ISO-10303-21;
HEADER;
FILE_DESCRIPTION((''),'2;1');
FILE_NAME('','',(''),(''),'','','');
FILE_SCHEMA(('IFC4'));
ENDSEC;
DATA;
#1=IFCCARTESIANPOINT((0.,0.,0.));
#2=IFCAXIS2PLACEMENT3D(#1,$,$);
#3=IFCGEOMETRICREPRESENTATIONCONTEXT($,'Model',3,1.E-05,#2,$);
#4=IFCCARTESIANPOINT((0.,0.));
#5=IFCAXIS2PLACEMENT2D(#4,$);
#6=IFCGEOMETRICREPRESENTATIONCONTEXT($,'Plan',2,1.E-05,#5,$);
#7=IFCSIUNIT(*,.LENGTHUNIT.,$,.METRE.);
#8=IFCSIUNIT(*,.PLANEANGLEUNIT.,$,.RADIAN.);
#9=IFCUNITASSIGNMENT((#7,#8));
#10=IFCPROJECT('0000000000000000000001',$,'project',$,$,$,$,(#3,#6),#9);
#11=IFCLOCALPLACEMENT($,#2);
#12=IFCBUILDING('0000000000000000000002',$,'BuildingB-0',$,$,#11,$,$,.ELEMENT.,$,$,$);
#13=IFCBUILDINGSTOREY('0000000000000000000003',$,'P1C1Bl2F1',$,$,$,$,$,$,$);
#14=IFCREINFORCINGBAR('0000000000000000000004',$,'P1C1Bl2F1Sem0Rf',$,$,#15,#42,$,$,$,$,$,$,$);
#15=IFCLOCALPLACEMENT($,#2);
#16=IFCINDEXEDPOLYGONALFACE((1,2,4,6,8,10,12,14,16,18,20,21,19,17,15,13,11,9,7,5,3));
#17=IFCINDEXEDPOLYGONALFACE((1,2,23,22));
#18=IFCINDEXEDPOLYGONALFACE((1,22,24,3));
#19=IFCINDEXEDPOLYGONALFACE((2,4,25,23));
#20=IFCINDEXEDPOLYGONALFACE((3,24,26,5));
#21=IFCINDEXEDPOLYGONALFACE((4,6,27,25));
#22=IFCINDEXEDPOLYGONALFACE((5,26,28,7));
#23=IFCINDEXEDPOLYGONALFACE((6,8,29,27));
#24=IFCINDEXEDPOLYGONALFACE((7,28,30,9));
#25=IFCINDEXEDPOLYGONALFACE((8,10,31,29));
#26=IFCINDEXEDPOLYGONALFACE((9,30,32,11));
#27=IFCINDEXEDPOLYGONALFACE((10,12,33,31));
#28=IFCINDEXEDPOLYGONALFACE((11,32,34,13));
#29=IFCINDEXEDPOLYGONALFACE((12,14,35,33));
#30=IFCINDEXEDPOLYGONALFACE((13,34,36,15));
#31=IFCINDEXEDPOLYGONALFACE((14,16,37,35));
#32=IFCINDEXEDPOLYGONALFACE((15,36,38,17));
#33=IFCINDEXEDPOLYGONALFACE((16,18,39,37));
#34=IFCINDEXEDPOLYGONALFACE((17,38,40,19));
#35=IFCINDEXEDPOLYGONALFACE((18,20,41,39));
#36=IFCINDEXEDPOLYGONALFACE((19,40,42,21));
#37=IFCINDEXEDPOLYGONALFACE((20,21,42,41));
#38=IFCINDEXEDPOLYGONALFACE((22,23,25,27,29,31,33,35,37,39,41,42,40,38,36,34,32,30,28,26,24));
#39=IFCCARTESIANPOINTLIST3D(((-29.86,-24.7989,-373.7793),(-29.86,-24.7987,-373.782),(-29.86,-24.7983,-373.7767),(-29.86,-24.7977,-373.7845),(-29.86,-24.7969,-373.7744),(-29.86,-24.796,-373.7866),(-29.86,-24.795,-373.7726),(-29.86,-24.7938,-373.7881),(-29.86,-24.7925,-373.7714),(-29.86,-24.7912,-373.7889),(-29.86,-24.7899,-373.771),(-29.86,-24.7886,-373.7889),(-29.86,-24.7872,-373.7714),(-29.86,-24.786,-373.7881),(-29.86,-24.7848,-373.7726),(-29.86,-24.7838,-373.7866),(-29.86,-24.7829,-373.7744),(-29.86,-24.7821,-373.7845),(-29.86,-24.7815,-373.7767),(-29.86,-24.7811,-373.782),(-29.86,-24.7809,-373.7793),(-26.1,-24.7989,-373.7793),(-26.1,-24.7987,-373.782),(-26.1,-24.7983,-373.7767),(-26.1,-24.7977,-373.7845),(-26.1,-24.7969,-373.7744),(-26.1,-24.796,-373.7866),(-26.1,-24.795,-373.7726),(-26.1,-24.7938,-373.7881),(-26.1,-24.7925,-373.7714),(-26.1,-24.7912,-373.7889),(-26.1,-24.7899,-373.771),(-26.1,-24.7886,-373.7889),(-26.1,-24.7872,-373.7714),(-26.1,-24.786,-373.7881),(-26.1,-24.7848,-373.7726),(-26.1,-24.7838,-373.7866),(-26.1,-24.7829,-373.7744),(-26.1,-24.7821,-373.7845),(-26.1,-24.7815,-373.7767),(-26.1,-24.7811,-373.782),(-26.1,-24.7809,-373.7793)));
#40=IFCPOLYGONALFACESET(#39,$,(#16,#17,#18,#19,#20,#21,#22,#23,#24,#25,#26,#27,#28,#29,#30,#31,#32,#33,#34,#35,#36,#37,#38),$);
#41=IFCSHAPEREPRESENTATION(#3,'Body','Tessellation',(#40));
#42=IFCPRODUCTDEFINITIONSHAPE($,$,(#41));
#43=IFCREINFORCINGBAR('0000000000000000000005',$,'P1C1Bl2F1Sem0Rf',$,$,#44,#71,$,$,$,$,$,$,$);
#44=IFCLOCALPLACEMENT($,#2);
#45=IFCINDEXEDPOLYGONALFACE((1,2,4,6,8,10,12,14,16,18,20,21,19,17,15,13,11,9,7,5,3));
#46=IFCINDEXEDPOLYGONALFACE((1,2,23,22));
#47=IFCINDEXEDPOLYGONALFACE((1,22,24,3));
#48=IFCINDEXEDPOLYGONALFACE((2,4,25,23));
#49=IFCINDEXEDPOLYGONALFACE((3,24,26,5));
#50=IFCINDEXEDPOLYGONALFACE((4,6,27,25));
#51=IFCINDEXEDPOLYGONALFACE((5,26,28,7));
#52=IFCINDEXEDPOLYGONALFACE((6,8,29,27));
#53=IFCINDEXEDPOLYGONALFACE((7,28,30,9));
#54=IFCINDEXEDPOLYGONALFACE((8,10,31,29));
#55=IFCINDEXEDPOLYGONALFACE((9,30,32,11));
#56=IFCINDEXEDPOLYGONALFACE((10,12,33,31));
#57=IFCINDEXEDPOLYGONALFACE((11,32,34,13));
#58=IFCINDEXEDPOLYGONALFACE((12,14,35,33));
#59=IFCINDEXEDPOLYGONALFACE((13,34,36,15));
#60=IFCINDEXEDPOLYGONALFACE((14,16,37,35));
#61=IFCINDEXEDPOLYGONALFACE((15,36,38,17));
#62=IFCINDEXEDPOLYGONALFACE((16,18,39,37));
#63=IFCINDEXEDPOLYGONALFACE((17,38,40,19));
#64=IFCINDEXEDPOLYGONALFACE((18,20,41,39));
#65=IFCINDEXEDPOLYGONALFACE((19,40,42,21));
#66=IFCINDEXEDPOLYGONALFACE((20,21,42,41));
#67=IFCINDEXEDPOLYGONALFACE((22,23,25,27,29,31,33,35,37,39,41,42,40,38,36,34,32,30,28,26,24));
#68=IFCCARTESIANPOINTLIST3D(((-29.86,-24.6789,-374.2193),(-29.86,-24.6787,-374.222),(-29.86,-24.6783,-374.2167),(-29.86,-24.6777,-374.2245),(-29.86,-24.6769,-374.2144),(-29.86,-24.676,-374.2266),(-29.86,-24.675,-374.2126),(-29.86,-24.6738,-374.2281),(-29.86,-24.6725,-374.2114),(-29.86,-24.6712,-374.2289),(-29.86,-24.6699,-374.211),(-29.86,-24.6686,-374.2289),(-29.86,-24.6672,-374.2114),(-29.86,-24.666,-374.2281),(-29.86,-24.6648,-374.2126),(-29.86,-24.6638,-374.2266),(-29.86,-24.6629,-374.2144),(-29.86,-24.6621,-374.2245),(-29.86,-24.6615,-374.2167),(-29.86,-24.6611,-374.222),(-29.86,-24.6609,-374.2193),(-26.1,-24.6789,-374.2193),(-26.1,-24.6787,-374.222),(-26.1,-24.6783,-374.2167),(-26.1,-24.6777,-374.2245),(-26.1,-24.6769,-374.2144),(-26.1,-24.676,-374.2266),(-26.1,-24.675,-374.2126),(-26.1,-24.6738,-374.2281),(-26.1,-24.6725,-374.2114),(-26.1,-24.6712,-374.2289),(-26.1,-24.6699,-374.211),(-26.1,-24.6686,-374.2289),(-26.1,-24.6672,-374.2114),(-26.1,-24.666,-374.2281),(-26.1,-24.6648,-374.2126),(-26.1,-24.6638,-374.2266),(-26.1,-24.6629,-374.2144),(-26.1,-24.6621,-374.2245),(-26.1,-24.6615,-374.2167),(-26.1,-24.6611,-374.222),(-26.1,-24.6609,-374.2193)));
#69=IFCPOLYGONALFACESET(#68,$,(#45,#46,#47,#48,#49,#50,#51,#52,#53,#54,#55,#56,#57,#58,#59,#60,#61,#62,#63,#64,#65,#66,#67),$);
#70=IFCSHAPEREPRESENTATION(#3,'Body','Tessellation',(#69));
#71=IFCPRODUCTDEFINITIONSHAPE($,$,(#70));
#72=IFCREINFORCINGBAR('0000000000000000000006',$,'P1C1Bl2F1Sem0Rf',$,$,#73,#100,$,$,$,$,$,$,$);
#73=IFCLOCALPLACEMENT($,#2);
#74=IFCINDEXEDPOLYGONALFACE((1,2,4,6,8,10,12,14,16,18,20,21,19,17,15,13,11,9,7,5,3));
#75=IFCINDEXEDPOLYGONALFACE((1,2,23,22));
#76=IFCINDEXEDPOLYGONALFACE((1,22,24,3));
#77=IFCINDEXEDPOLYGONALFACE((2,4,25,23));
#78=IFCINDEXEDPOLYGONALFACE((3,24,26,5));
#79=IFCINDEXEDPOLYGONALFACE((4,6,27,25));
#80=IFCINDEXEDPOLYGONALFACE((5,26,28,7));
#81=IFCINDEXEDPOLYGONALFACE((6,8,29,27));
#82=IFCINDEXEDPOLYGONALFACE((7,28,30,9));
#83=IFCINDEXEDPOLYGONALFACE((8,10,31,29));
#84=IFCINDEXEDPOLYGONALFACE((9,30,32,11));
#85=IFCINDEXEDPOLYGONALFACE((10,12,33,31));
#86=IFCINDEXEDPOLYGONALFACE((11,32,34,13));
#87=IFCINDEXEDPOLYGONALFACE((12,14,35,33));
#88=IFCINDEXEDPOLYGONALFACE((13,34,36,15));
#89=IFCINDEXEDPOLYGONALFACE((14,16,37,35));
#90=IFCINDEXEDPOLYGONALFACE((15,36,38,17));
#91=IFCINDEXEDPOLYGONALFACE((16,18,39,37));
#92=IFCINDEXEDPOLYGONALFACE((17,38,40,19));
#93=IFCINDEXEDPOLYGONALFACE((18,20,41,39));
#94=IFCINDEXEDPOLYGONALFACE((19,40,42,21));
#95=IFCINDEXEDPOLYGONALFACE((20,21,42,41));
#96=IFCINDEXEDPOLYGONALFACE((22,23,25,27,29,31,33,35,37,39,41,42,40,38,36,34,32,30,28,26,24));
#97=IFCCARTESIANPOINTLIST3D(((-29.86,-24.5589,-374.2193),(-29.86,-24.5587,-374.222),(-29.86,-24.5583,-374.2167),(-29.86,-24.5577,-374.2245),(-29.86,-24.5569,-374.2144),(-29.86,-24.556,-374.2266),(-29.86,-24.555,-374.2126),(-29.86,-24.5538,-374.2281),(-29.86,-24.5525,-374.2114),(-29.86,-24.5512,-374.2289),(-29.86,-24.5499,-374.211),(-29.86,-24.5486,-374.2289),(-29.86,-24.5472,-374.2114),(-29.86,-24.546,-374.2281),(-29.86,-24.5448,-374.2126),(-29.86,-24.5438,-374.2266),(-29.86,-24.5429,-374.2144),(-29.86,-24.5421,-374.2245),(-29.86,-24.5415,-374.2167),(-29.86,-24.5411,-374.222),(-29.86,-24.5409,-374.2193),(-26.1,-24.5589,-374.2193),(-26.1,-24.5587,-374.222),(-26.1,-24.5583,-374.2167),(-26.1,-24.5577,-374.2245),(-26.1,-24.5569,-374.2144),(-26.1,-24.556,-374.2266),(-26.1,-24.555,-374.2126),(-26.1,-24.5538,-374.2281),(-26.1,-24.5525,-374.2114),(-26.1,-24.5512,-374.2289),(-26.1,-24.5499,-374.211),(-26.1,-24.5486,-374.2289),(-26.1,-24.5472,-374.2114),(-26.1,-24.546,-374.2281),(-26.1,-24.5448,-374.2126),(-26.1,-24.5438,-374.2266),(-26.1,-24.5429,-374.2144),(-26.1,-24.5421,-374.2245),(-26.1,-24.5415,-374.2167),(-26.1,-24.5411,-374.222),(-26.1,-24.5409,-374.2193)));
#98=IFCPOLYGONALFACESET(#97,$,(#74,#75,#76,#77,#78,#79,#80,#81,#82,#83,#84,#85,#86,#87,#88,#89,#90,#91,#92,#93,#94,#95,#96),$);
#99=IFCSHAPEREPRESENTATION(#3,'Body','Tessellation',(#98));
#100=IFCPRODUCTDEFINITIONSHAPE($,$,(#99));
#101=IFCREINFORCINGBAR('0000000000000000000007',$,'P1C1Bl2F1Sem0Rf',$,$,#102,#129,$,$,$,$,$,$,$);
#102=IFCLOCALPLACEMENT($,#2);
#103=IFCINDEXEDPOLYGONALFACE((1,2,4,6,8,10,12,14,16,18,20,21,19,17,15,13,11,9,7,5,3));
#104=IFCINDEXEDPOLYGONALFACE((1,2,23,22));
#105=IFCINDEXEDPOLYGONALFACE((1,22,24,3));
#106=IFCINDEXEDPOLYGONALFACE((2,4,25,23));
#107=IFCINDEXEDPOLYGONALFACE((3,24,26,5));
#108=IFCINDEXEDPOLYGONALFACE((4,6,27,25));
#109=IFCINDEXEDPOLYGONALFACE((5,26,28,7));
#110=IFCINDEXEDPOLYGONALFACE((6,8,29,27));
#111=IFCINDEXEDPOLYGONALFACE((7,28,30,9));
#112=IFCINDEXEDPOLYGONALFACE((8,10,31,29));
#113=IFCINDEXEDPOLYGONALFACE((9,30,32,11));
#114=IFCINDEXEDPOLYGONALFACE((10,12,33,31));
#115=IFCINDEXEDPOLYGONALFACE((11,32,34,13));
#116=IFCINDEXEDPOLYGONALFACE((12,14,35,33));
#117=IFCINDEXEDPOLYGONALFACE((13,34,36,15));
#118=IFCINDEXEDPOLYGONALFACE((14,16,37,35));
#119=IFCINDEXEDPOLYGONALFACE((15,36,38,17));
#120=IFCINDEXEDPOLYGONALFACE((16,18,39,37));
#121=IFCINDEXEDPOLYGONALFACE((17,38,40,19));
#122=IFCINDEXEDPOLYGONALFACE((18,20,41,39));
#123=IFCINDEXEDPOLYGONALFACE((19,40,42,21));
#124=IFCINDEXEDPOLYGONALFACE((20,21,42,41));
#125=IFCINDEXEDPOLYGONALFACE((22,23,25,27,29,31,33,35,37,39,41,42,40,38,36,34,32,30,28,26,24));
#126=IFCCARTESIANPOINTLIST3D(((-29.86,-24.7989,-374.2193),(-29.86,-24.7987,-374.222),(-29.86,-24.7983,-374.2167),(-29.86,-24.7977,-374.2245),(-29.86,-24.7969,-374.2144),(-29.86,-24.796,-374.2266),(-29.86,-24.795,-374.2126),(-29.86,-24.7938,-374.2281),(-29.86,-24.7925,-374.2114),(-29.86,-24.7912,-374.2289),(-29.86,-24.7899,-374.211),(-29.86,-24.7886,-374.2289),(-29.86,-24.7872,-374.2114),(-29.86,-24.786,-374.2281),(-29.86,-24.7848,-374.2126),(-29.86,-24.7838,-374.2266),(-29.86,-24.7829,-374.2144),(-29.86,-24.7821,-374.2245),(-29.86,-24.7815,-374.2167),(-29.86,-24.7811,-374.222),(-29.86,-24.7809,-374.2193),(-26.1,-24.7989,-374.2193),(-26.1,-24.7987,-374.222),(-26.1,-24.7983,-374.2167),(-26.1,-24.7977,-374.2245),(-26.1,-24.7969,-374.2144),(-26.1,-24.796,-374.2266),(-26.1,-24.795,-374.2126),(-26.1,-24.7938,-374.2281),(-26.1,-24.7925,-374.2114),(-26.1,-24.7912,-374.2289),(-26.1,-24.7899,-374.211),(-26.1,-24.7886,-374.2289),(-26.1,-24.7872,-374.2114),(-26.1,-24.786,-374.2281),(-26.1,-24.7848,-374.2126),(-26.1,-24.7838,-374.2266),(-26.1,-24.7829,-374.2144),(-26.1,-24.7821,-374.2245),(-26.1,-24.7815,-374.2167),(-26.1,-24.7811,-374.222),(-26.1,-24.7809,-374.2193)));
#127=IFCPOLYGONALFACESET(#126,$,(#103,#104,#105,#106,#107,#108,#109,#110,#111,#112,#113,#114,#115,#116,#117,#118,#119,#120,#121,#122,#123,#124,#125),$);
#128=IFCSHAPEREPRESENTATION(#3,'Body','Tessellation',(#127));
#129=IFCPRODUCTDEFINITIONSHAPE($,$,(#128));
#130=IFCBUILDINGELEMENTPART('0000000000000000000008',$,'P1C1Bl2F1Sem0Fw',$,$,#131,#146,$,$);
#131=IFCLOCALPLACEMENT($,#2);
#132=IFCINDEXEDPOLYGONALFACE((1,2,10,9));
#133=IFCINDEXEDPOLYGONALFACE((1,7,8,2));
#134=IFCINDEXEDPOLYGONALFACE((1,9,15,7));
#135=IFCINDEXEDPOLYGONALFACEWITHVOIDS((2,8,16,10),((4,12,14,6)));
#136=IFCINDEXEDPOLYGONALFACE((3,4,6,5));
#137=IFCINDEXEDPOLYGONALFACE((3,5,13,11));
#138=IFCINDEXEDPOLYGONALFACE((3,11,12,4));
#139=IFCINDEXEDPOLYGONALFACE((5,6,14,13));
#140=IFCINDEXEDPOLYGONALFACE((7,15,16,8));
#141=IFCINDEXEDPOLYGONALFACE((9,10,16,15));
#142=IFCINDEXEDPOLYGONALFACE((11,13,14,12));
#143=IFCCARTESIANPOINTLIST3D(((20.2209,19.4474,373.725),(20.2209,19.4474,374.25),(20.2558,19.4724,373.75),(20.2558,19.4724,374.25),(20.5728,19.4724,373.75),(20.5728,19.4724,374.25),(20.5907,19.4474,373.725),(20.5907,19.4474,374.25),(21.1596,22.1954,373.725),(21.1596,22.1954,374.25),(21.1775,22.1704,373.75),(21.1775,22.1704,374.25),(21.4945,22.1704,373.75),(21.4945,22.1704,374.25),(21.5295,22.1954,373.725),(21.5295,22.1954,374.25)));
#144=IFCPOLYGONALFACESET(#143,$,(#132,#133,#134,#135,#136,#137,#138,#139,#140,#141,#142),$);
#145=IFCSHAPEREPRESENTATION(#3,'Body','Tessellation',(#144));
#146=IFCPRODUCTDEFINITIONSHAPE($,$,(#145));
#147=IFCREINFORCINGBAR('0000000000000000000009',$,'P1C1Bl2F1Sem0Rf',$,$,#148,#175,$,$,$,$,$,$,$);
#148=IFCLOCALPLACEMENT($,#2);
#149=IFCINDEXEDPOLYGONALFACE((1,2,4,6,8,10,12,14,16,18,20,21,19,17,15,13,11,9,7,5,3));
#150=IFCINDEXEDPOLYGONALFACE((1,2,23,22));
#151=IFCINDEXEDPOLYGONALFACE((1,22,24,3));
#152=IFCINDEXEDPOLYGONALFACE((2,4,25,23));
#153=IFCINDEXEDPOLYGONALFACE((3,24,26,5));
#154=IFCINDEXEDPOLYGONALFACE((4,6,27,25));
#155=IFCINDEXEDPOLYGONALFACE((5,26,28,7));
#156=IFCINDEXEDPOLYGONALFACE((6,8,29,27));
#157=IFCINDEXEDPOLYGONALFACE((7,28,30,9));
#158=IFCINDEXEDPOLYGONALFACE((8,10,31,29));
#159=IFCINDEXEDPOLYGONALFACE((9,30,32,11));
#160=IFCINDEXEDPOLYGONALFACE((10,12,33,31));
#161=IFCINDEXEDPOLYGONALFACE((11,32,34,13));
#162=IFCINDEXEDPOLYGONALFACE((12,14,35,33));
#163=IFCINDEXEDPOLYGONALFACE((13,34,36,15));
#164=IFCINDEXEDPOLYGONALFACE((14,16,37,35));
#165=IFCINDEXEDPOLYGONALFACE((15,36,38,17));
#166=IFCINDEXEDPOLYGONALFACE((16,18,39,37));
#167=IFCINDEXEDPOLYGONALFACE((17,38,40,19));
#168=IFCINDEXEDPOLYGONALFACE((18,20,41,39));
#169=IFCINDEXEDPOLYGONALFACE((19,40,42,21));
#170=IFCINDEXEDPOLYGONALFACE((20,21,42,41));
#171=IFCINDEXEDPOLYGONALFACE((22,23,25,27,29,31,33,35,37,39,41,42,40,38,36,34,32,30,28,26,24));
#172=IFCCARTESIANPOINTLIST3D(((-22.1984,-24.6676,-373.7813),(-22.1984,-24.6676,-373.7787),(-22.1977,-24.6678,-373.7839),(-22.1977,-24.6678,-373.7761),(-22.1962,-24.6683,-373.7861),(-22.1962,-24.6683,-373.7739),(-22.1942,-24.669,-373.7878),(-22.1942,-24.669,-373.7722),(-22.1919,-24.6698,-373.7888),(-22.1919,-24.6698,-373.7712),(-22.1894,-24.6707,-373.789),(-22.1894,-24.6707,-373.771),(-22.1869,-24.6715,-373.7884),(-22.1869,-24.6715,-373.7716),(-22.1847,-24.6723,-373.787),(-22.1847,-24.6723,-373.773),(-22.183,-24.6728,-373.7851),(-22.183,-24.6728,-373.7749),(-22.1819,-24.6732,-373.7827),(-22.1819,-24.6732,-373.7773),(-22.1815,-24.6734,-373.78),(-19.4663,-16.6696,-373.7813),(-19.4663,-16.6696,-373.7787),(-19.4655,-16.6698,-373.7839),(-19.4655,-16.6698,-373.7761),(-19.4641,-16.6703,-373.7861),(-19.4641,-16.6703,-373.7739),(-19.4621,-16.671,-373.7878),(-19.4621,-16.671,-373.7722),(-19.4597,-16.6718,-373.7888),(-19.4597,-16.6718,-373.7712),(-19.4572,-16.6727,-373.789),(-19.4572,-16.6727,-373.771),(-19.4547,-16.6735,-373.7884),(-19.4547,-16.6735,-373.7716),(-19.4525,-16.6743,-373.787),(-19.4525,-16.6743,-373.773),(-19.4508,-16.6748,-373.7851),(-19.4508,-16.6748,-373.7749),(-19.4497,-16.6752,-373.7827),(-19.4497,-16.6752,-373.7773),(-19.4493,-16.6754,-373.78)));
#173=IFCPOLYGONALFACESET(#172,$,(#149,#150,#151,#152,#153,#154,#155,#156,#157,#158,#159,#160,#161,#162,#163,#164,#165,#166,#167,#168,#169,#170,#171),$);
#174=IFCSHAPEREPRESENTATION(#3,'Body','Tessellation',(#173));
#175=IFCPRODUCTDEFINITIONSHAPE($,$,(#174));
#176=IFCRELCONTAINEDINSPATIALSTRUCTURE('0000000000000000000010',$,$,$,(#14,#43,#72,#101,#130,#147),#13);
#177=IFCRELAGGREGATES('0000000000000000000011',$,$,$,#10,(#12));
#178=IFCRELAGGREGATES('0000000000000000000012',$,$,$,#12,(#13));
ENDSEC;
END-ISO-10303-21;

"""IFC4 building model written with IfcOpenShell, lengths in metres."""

from ifc_helpers import new_model, entity, si_unit, origin, origin_2d, place, context, project, spatial, polyline, outline, extrude, element, save


model = new_model("IFC4")

# Units and contexts
model_context = context("Model", 3, precision=1e-05, world=origin())
plan_context = context("Plan", 2, precision=1e-05, world=origin_2d())
ifc_project = project(units=[si_unit("LENGTHUNIT", "METRE"), si_unit("PLANEANGLEUNIT", "RADIAN")], contexts=[model_context, plan_context])

# Building, storey
building_placement = place(None, origin())
building = spatial("IfcBuilding", under=ifc_project, at=building_placement, Name="BuildingB-0", CompositionType="ELEMENT")
storey = spatial("IfcBuildingStorey", under=building, Name="P1C1Bl2F1")

# Reinforcing bars
element("IfcReinforcingBar", 1, inside=storey, Name="P1C1Bl2F1Sem0Rf", context=model_context, shape_type="SweptSolid", body=[
    entity("IfcSurfaceCurveSweptAreaSolid", entity("IfcCircleProfileDef", "AREA", None, None, 0.009), None, entity("IfcPolyline", [entity("IfcCartesianPoint", [26.1, 24.7899, 373.78]), entity("IfcCartesianPoint", [29.86, 24.7899, 373.78])]), None, None, entity("IfcPlane", entity("IfcAxis2Placement3D", entity("IfcCartesianPoint", [26.1, 24.7899, 373.78]), entity("IfcDirection", [0.0, 0.0, 1.0]), entity("IfcDirection", [1.0, 0.0, 0.0])))),
])
element("IfcReinforcingBar", 2, inside=storey, Name="P1C1Bl2F1Sem0Rf", context=model_context, shape_type="SweptSolid", body=[
    entity("IfcSurfaceCurveSweptAreaSolid", entity("IfcCircleProfileDef", "AREA", None, None, 0.009), None, entity("IfcPolyline", [entity("IfcCartesianPoint", [26.1, 24.6699, 374.22]), entity("IfcCartesianPoint", [29.86, 24.6699, 374.22])]), None, None, entity("IfcPlane", entity("IfcAxis2Placement3D", entity("IfcCartesianPoint", [26.1, 24.6699, 374.22]), entity("IfcDirection", [0.0, 0.0, 1.0]), entity("IfcDirection", [1.0, 0.0, 0.0])))),
])
element("IfcReinforcingBar", 3, inside=storey, Name="P1C1Bl2F1Sem0Rf", context=model_context, shape_type="SweptSolid", body=[
    entity("IfcSurfaceCurveSweptAreaSolid", entity("IfcCircleProfileDef", "AREA", None, None, 0.009), None, entity("IfcPolyline", [entity("IfcCartesianPoint", [26.1, 24.5499, 374.22]), entity("IfcCartesianPoint", [29.86, 24.5499, 374.22])]), None, None, entity("IfcPlane", entity("IfcAxis2Placement3D", entity("IfcCartesianPoint", [26.1, 24.5499, 374.22]), entity("IfcDirection", [0.0, 0.0, 1.0]), entity("IfcDirection", [1.0, 0.0, 0.0])))),
])
element("IfcReinforcingBar", 4, inside=storey, Name="P1C1Bl2F1Sem0Rf", context=model_context, shape_type="SweptSolid", body=[
    entity("IfcSurfaceCurveSweptAreaSolid", entity("IfcCircleProfileDef", "AREA", None, None, 0.009), None, entity("IfcPolyline", [entity("IfcCartesianPoint", [26.1, 24.7899, 374.22]), entity("IfcCartesianPoint", [29.86, 24.7899, 374.22])]), None, None, entity("IfcPlane", entity("IfcAxis2Placement3D", entity("IfcCartesianPoint", [26.1, 24.7899, 374.22]), entity("IfcDirection", [0.0, 0.0, 1.0]), entity("IfcDirection", [1.0, 0.0, 0.0])))),
])

# Building element part, opening
building_element_part_1 = element("IfcBuildingElementPart", 5, inside=storey, Name="P1C1Bl2F1Sem0Fw", context=model_context, shape_type="SweptSolid", body=[
    extrude(outline(polyline([(20.2209, 19.4474, 373.725), (20.5907, 19.4474, 373.725), (21.5295, 22.1954, 373.725), (21.1596, 22.1954, 373.725), (20.2209, 19.4474, 373.725)])), None, (0.0, 0.0, 1.0), 0.525),
])
element("IfcOpeningElement", 6, inside=storey, cuts=building_element_part_1, context=model_context, shape_type="SweptSolid", body=[
    extrude(outline(polyline([(20.2558, 19.4724, 373.75), (20.5728, 19.4724, 373.75), (21.4945, 22.1704, 373.75), (21.1775, 22.1704, 373.75), (20.2558, 19.4724, 373.75)])), None, (0.0, 0.0, 1.0), 0.5),
])

# Reinforcing bar
element("IfcReinforcingBar", 7, inside=storey, Name="P1C1Bl2F1Sem0Rf", context=model_context, shape_type="SweptSolid", body=[
    entity("IfcSurfaceCurveSweptAreaSolid", entity("IfcCircleProfileDef", "AREA", None, None, 0.009), None, entity("IfcPolyline", [entity("IfcCartesianPoint", [19.4578, 16.6724, 373.78]), entity("IfcCartesianPoint", [22.19, 24.6704, 373.78])]), None, None, entity("IfcPlane", entity("IfcAxis2Placement3D", entity("IfcCartesianPoint", [19.4578, 16.6724, 373.78]), entity("IfcDirection", [0.0, 0.0, 1.0]), entity("IfcDirection", [1.0, 0.0, 0.0])))),
])

save(model, "model.ifc")
